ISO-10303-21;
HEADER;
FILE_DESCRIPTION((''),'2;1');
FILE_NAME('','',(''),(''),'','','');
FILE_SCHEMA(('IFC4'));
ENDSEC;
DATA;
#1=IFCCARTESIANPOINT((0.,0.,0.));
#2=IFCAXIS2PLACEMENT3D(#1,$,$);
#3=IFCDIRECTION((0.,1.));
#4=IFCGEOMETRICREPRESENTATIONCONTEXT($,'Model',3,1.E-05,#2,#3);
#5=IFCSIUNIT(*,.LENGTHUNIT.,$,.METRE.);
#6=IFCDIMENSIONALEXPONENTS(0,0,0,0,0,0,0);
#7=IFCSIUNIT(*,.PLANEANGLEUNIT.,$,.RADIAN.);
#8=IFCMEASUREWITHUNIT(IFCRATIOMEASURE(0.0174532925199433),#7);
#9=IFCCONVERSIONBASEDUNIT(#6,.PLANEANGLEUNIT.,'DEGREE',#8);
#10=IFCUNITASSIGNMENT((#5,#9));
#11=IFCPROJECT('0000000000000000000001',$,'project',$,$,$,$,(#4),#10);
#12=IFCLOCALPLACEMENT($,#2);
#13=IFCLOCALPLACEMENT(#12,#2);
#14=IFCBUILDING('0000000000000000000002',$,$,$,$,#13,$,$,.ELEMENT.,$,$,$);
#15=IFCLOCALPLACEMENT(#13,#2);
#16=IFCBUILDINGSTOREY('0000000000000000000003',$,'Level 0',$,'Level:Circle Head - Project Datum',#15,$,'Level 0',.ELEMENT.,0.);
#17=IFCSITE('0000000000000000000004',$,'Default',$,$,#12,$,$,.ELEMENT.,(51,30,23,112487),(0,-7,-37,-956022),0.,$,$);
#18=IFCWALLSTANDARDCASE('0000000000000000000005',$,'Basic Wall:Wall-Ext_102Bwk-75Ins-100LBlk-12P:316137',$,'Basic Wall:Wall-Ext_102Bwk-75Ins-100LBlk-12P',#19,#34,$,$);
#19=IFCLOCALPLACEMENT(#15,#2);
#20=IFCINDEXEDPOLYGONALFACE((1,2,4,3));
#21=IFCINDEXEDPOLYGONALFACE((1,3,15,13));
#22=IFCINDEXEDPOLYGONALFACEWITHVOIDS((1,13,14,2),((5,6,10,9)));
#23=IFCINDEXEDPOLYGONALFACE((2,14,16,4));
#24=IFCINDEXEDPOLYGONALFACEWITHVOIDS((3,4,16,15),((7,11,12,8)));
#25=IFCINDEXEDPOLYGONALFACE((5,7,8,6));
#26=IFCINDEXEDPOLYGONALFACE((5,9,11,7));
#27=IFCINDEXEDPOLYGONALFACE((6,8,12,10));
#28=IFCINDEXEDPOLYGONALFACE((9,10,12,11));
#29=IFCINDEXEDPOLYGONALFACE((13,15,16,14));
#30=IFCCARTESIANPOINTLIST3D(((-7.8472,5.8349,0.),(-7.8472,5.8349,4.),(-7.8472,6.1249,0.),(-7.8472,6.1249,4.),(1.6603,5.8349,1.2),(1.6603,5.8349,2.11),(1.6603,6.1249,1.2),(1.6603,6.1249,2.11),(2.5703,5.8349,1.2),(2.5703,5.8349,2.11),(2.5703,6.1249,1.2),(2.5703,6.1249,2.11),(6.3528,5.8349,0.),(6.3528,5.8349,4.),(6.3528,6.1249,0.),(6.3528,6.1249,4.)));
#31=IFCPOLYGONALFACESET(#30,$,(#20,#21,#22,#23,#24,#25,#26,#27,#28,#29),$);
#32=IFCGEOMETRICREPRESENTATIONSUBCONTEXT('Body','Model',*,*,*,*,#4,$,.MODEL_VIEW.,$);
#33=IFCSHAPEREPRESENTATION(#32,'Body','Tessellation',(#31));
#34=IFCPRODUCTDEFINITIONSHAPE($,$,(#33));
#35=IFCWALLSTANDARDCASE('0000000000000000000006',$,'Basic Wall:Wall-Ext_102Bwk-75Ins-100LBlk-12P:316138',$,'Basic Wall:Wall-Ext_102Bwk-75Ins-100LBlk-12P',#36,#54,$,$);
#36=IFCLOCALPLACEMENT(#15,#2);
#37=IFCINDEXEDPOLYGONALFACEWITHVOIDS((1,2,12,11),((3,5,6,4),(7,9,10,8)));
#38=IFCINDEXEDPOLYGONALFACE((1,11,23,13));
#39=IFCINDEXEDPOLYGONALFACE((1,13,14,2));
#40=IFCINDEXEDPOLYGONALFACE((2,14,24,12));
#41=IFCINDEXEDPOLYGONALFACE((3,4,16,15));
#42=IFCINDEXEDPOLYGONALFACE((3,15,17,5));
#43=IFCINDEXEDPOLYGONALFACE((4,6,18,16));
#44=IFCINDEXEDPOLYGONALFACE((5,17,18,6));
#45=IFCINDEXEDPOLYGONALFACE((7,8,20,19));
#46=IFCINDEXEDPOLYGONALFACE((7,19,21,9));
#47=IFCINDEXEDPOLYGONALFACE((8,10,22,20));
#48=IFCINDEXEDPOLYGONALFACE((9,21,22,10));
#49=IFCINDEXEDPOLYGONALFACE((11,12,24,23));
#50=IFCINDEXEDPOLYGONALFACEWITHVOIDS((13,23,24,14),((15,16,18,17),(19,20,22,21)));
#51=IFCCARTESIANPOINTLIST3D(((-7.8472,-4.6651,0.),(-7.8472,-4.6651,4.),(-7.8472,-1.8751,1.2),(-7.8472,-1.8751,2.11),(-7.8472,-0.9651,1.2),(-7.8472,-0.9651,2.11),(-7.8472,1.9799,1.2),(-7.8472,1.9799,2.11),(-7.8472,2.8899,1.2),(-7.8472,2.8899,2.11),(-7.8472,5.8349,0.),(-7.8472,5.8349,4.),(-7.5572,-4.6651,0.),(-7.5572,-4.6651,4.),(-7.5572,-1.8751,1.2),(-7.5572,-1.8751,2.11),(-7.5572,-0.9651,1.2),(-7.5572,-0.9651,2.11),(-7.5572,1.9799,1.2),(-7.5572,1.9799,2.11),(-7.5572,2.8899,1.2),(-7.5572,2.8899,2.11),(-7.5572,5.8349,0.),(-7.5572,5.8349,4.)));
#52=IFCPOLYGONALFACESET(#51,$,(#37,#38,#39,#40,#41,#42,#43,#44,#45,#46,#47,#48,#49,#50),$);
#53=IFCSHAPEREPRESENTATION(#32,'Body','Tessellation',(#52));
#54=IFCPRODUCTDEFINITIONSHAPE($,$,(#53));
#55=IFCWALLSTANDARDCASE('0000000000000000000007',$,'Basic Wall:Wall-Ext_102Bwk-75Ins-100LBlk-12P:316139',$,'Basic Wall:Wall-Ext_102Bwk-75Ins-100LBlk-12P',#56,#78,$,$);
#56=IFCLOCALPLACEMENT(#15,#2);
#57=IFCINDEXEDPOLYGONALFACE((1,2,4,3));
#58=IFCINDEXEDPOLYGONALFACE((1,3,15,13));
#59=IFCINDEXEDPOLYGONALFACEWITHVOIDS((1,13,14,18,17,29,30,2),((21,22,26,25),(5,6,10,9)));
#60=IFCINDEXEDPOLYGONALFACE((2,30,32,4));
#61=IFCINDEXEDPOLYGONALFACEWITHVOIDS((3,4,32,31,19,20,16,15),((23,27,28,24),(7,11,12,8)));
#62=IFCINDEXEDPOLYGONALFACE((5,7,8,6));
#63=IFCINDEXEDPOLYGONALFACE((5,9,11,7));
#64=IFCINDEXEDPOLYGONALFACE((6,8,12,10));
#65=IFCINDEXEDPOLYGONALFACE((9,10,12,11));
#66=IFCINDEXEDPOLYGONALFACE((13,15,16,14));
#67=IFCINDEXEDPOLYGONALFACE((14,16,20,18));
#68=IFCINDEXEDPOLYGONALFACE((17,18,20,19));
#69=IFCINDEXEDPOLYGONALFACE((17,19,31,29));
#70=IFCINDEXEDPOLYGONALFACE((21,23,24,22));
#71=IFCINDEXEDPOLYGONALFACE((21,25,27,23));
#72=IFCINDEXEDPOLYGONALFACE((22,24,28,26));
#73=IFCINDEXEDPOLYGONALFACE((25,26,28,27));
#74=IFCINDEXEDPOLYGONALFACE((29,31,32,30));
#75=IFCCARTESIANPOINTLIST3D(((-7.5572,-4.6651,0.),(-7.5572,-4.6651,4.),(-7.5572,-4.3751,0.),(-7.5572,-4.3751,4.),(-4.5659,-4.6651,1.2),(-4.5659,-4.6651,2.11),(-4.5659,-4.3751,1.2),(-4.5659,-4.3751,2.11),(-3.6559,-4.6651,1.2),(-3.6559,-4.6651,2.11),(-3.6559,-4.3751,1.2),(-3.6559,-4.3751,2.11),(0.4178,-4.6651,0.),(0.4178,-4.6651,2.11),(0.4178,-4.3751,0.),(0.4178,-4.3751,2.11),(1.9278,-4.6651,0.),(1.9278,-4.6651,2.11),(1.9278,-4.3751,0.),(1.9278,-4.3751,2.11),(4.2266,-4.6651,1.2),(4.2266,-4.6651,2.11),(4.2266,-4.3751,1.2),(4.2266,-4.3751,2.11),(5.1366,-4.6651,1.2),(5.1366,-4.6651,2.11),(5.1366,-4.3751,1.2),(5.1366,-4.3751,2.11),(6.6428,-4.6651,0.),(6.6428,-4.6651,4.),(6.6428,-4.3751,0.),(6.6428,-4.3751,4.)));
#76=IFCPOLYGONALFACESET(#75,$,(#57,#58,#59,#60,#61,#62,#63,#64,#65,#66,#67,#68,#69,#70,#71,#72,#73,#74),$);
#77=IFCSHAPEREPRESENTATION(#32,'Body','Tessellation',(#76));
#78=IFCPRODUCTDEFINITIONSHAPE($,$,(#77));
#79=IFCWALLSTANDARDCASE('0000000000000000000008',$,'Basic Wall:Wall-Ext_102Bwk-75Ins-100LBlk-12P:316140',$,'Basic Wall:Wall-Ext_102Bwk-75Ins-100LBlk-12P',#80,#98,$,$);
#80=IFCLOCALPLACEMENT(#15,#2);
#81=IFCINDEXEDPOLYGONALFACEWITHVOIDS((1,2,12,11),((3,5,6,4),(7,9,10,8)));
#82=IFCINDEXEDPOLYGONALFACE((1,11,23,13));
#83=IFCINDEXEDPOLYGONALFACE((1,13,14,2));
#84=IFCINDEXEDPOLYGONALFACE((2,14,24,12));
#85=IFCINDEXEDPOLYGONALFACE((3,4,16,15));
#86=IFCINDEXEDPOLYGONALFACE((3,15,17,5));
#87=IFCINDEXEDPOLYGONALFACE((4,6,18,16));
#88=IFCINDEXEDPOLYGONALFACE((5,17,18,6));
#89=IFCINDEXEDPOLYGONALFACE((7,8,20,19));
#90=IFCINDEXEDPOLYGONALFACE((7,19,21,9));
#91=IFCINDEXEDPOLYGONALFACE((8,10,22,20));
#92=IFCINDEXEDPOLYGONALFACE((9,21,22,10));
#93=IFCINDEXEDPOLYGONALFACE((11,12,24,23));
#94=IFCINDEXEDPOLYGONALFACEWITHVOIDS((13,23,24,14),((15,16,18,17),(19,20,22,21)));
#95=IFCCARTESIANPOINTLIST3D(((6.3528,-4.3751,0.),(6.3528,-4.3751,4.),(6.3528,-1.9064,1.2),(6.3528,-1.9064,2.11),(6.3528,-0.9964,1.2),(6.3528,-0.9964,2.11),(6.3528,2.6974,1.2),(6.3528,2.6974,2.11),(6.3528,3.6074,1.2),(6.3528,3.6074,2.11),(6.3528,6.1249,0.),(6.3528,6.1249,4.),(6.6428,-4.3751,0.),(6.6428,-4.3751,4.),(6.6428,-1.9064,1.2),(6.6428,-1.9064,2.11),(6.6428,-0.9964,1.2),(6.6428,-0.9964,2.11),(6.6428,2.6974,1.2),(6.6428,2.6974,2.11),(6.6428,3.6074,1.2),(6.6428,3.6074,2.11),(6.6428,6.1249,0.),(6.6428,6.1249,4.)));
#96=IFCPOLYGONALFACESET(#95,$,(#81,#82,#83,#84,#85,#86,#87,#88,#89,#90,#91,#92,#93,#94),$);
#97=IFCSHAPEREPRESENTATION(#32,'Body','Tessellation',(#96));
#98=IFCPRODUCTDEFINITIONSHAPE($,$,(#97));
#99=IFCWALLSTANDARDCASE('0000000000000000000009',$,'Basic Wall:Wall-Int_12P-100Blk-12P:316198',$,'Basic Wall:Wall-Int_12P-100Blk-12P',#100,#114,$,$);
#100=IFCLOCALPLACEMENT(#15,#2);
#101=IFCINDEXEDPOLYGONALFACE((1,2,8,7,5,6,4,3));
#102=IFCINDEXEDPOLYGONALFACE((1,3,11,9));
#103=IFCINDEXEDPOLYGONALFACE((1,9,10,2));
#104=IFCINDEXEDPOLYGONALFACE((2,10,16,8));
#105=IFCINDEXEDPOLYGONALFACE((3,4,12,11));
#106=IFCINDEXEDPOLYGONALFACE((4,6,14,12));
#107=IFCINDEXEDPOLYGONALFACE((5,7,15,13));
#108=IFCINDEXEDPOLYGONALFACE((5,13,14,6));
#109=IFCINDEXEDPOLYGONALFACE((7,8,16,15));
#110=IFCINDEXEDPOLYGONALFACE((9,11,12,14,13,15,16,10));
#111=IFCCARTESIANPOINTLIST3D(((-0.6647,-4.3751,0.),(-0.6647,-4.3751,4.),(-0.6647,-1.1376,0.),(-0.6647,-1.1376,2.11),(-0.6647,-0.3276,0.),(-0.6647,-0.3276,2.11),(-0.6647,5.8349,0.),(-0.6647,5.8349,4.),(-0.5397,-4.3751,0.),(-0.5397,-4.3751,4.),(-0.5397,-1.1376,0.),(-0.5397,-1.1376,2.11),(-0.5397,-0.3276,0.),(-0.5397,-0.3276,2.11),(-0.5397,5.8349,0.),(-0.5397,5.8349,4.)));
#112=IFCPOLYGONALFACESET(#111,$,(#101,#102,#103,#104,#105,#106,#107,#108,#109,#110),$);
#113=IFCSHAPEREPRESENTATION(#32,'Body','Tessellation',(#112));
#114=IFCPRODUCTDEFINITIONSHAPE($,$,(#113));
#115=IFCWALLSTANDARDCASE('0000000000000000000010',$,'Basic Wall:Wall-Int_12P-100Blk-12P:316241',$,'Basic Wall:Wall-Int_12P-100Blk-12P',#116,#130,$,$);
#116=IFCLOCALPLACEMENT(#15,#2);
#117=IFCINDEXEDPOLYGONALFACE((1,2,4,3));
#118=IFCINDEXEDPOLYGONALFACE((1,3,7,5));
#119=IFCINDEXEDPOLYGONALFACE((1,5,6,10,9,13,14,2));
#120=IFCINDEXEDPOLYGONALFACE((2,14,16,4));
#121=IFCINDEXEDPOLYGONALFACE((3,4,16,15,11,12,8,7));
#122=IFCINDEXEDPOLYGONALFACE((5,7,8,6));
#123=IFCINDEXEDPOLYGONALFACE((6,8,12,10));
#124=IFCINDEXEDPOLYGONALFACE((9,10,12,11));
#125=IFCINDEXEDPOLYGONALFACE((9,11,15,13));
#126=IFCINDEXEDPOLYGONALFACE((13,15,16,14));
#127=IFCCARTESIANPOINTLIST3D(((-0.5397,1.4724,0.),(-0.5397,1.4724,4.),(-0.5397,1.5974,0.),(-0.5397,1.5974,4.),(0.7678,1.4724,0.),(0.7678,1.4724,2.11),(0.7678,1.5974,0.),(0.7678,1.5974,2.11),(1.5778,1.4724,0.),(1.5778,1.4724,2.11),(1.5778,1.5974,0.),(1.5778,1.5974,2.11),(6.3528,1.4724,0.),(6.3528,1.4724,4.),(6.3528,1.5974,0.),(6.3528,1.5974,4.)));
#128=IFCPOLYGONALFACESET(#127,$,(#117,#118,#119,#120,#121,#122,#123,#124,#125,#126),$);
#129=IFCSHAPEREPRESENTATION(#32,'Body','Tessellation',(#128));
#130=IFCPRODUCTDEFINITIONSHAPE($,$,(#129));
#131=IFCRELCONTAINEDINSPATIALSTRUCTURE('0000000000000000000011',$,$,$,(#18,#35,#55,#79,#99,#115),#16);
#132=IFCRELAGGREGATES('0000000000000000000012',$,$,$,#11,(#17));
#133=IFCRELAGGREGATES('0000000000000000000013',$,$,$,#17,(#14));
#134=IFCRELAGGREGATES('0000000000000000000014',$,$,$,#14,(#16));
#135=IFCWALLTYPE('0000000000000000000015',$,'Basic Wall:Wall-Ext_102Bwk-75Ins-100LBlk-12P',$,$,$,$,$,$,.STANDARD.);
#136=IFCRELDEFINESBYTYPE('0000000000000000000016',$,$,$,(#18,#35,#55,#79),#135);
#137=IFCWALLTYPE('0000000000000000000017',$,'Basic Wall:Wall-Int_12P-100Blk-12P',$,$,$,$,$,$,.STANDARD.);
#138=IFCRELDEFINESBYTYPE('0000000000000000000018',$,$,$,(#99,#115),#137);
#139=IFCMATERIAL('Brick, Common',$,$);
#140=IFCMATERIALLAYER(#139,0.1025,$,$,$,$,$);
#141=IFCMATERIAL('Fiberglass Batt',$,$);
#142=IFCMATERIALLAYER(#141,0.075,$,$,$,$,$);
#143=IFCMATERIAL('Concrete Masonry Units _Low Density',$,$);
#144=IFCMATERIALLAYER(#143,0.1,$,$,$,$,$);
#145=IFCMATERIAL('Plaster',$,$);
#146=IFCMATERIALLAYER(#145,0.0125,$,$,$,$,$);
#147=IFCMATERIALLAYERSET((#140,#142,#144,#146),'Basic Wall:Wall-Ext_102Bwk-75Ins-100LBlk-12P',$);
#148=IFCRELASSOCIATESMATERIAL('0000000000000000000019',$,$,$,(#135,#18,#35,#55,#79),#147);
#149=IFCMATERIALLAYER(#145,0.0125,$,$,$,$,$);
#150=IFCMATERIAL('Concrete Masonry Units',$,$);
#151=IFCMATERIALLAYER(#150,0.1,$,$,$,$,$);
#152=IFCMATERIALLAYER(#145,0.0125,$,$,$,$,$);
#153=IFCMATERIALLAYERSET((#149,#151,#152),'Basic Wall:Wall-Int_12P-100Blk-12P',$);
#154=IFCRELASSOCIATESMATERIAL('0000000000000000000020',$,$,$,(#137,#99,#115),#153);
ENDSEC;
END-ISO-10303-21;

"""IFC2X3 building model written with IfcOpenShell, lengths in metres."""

from ifc_helpers import new_model, entity, si_unit, converted_unit, direction, frame, frame_2d, origin, place, context, subcontext, project, spatial, rectangle, extrude, material, layer, layer_set, layer_usage, type_object, element, save


model = new_model("IFC2X3")

# Units and contexts
model_context = context("Model", 3, precision=1e-05, world=origin(), true_north=direction((0.0, 1.0)))
body_context = subcontext(model_context, "Body", "Model", "MODEL_VIEW")
ifc_project = project(units=[si_unit("LENGTHUNIT", "METRE"), converted_unit("PLANEANGLEUNIT", "DEGREE", entity("IfcRatioMeasure", 0.0174532925199433), si_unit("PLANEANGLEUNIT", "RADIAN"), dimensions=[0, 0, 0, 0, 0, 0, 0])], contexts=[model_context])

# Site, building, storey
site_placement = place(None, origin())
site = spatial("IfcSite", under=ifc_project, at=site_placement, Name="Default", CompositionType="ELEMENT", RefLatitude=(51, 30, 23, 112487), RefLongitude=(0, -7, -37, -956022), RefElevation=0.0)
building_placement = place(site_placement, origin())
building = spatial("IfcBuilding", under=site, at=building_placement, CompositionType="ELEMENT")
storey_placement = place(building_placement, origin())
storey = spatial("IfcBuildingStorey", under=building, at=storey_placement, Name="Level 0", ObjectType="Level:Circle Head - Project Datum", LongName="Level 0", CompositionType="ELEMENT", Elevation=0.0)

# Wall, opening
ifc_material_1 = material(Name="Brick, Common")
ifc_layer_1 = layer(ifc_material_1, 0.1025)
ifc_material_2 = material(Name="Fiberglass Batt")
ifc_layer_2 = layer(ifc_material_2, 0.075)
ifc_material_3 = material(Name="Concrete Masonry Units _Low Density")
ifc_layer_3 = layer(ifc_material_3, 0.1)
ifc_material_4 = material(Name="Plaster")
ifc_layer_4 = layer(ifc_material_4, 0.0125)
ifc_layer_set_1 = layer_set([ifc_layer_1, ifc_layer_2, ifc_layer_3, ifc_layer_4], Name="Basic Wall:Wall-Ext_102Bwk-75Ins-100LBlk-12P")
ifc_layer_usage_1 = layer_usage(ifc_layer_set_1, "AXIS2", "NEGATIVE", 0.145)
wall_type_1 = type_object("IfcWallType", Name="Basic Wall:Wall-Ext_102Bwk-75Ins-100LBlk-12P", PredefinedType="STANDARD", material=ifc_layer_set_1)
wall_1_placement = place(storey_placement, frame((-7.8472, 5.9799, 0.0)))
wall_1 = element("IfcWallStandardCase", 1, at=wall_1_placement, inside=storey, type_object=wall_type_1, material=ifc_layer_usage_1, Name="Basic Wall:Wall-Ext_102Bwk-75Ins-100LBlk-12P:316137", ObjectType="Basic Wall:Wall-Ext_102Bwk-75Ins-100LBlk-12P", context=body_context, shape_type="SweptSolid", body=[
    extrude(rectangle(XDim=14.2, YDim=0.29, at=frame_2d((7.1, 0.0), x_axis=(-1.0, 0.0))), origin(), (0.0, 0.0, 1.0), 4.0),
])
opening_1_placement = place(wall_1_placement, frame((9.5075, -0.145, 1.2)))
element("IfcOpeningElement", 2, at=opening_1_placement, cuts=wall_1, ObjectType="Opening", context=body_context, shape_type="SweptSolid", body=[
    extrude(rectangle(XDim=0.91, YDim=0.91, at=frame_2d((0.455, 0.455), x_axis=(-1.0, 0.0))), frame((0.0, 0.0, 0.0), z_axis=(0.0, 1.0, 0.0), x_axis=(0.0, 0.0, 1.0)), (0.0, 0.0, 1.0), 0.29),
])

# Walls, openings
ifc_layer_usage_2 = layer_usage(ifc_layer_set_1, "AXIS2", "NEGATIVE", 0.145)
wall_2_placement = place(storey_placement, frame((-7.7022, -4.6651, 0.0), z_axis=(0.0, 0.0, 1.0), x_axis=(0.0, 1.0, 0.0)))
wall_2 = element("IfcWallStandardCase", 3, at=wall_2_placement, inside=storey, type_object=wall_type_1, material=ifc_layer_usage_2, Name="Basic Wall:Wall-Ext_102Bwk-75Ins-100LBlk-12P:316138", ObjectType="Basic Wall:Wall-Ext_102Bwk-75Ins-100LBlk-12P", context=body_context, shape_type="SweptSolid", body=[
    extrude(rectangle(XDim=10.5, YDim=0.29, at=frame_2d((5.25, 0.0), x_axis=(-1.0, 0.0))), origin(), (0.0, 0.0, 1.0), 4.0),
])
opening_2_placement = place(wall_2_placement, frame((2.79, -0.145, 1.2)))
element("IfcOpeningElement", 4, at=opening_2_placement, cuts=wall_2, ObjectType="Opening", context=body_context, shape_type="SweptSolid", body=[
    extrude(rectangle(XDim=0.91, YDim=0.91, at=frame_2d((0.455, 0.455), x_axis=(-1.0, 0.0))), frame((0.0, 0.0, 0.0), z_axis=(0.0, 1.0, 0.0), x_axis=(0.0, 0.0, 1.0)), (0.0, 0.0, 1.0), 0.29),
])
opening_3_placement = place(wall_2_placement, frame((6.645, -0.145, 1.2)))
element("IfcOpeningElement", 5, at=opening_3_placement, cuts=wall_2, ObjectType="Opening", context=body_context, shape_type="SweptSolid", body=[
    extrude(rectangle(XDim=0.91, YDim=0.91, at=frame_2d((0.455, 0.455), x_axis=(-1.0, 0.0))), frame((0.0, 0.0, 0.0), z_axis=(0.0, 1.0, 0.0), x_axis=(0.0, 0.0, 1.0)), (0.0, 0.0, 1.0), 0.29),
])
ifc_layer_usage_3 = layer_usage(ifc_layer_set_1, "AXIS2", "NEGATIVE", 0.145)
wall_3_placement = place(storey_placement, frame((6.6428, -4.5201, 0.0), z_axis=(0.0, 0.0, 1.0), x_axis=(-1.0, 0.0, 0.0)))
wall_3 = element("IfcWallStandardCase", 6, at=wall_3_placement, inside=storey, type_object=wall_type_1, material=ifc_layer_usage_3, Name="Basic Wall:Wall-Ext_102Bwk-75Ins-100LBlk-12P:316139", ObjectType="Basic Wall:Wall-Ext_102Bwk-75Ins-100LBlk-12P", context=body_context, shape_type="SweptSolid", body=[
    extrude(rectangle(XDim=14.2, YDim=0.29, at=frame_2d((7.1, 0.0), x_axis=(-1.0, 0.0))), origin(), (0.0, 0.0, 1.0), 4.0),
])
opening_4_placement = place(wall_3_placement, frame((6.225, 0.145, 0.0)))
element("IfcOpeningElement", 7, at=opening_4_placement, cuts=wall_3, ObjectType="Opening", context=body_context, shape_type="SweptSolid", body=[
    extrude(rectangle(XDim=2.11, YDim=1.51, at=frame_2d((1.055, 0.755), x_axis=(-1.0, 0.0))), frame((0.0, 0.0, 0.0), z_axis=(0.0, -1.0, 0.0), x_axis=(0.0, 0.0, 1.0)), (0.0, 0.0, 1.0), 0.29),
])
opening_5_placement = place(wall_3_placement, frame((11.2088, 0.145, 1.2)))
element("IfcOpeningElement", 8, at=opening_5_placement, cuts=wall_3, ObjectType="Opening", context=body_context, shape_type="SweptSolid", body=[
    extrude(rectangle(XDim=0.91, YDim=0.91, at=frame_2d((0.455, 0.455), x_axis=(-1.0, 0.0))), frame((0.0, 0.0, 0.0), z_axis=(0.0, -1.0, 0.0), x_axis=(0.0, 0.0, 1.0)), (0.0, 0.0, 1.0), 0.29),
])
opening_6_placement = place(wall_3_placement, frame((2.4162, 0.145, 1.2)))
element("IfcOpeningElement", 9, at=opening_6_placement, cuts=wall_3, ObjectType="Opening", context=body_context, shape_type="SweptSolid", body=[
    extrude(rectangle(XDim=0.91, YDim=0.91, at=frame_2d((0.455, 0.455), x_axis=(-1.0, 0.0))), frame((0.0, 0.0, 0.0), z_axis=(0.0, -1.0, 0.0), x_axis=(0.0, 0.0, 1.0)), (0.0, 0.0, 1.0), 0.29),
])
ifc_layer_usage_4 = layer_usage(ifc_layer_set_1, "AXIS2", "NEGATIVE", 0.145)
wall_4_placement = place(storey_placement, frame((6.4978, 6.1249, 0.0), z_axis=(0.0, 0.0, 1.0), x_axis=(0.0, -1.0, 0.0)))
wall_4 = element("IfcWallStandardCase", 10, at=wall_4_placement, inside=storey, type_object=wall_type_1, material=ifc_layer_usage_4, Name="Basic Wall:Wall-Ext_102Bwk-75Ins-100LBlk-12P:316140", ObjectType="Basic Wall:Wall-Ext_102Bwk-75Ins-100LBlk-12P", context=body_context, shape_type="SweptSolid", body=[
    extrude(rectangle(XDim=10.5, YDim=0.29, at=frame_2d((5.25, 0.0), x_axis=(-1.0, 0.0))), origin(), (0.0, 0.0, 1.0), 4.0),
])
opening_7_placement = place(wall_4_placement, frame((2.5175, -0.145, 1.2)))
element("IfcOpeningElement", 11, at=opening_7_placement, cuts=wall_4, ObjectType="Opening", context=body_context, shape_type="SweptSolid", body=[
    extrude(rectangle(XDim=0.91, YDim=0.91, at=frame_2d((0.455, 0.455), x_axis=(-1.0, 0.0))), frame((0.0, 0.0, 0.0), z_axis=(0.0, 1.0, 0.0), x_axis=(0.0, 0.0, 1.0)), (0.0, 0.0, 1.0), 0.29),
])
opening_8_placement = place(wall_4_placement, frame((7.1213, -0.145, 1.2)))
element("IfcOpeningElement", 12, at=opening_8_placement, cuts=wall_4, ObjectType="Opening", context=body_context, shape_type="SweptSolid", body=[
    extrude(rectangle(XDim=0.91, YDim=0.91, at=frame_2d((0.455, 0.455), x_axis=(-1.0, 0.0))), frame((0.0, 0.0, 0.0), z_axis=(0.0, 1.0, 0.0), x_axis=(0.0, 0.0, 1.0)), (0.0, 0.0, 1.0), 0.29),
])

# Walls, openings
ifc_layer_5 = layer(ifc_material_4, 0.0125)
ifc_material_5 = material(Name="Concrete Masonry Units")
ifc_layer_6 = layer(ifc_material_5, 0.1)
ifc_layer_7 = layer(ifc_material_4, 0.0125)
ifc_layer_set_2 = layer_set([ifc_layer_5, ifc_layer_6, ifc_layer_7], Name="Basic Wall:Wall-Int_12P-100Blk-12P")
ifc_layer_usage_5 = layer_usage(ifc_layer_set_2, "AXIS2", "NEGATIVE", 0.0625)
wall_type_2 = type_object("IfcWallType", Name="Basic Wall:Wall-Int_12P-100Blk-12P", PredefinedType="STANDARD", material=ifc_layer_set_2)
wall_5_placement = place(storey_placement, frame((-0.6022, 5.8349, 0.0), z_axis=(0.0, 0.0, 1.0), x_axis=(0.0, -1.0, 0.0)))
wall_5 = element("IfcWallStandardCase", 13, at=wall_5_placement, inside=storey, type_object=wall_type_2, material=ifc_layer_usage_5, Name="Basic Wall:Wall-Int_12P-100Blk-12P:316198", ObjectType="Basic Wall:Wall-Int_12P-100Blk-12P", context=body_context, shape_type="SweptSolid", body=[
    extrude(rectangle(XDim=10.21, YDim=0.125, at=frame_2d((5.105, 0.0), x_axis=(-1.0, 0.0))), origin(), (0.0, 0.0, 1.0), 4.0),
])
opening_9_placement = place(wall_5_placement, frame((6.1625, -0.0625, 0.0)))
element("IfcOpeningElement", 14, at=opening_9_placement, cuts=wall_5, ObjectType="Opening", context=body_context, shape_type="SweptSolid", body=[
    extrude(rectangle(XDim=2.11, YDim=0.81, at=frame_2d((1.055, 0.405), x_axis=(1.0, 0.0))), frame((0.0, 0.0, 0.0), z_axis=(0.0, 1.0, 0.0), x_axis=(0.0, 0.0, 1.0)), (0.0, 0.0, 1.0), 0.125),
])
ifc_layer_usage_6 = layer_usage(ifc_layer_set_2, "AXIS2", "NEGATIVE", 0.0625)
wall_6_placement = place(storey_placement, frame((-0.5397, 1.5349, 0.0)))
wall_6 = element("IfcWallStandardCase", 15, at=wall_6_placement, inside=storey, type_object=wall_type_2, material=ifc_layer_usage_6, Name="Basic Wall:Wall-Int_12P-100Blk-12P:316241", ObjectType="Basic Wall:Wall-Int_12P-100Blk-12P", context=body_context, shape_type="SweptSolid", body=[
    extrude(rectangle(XDim=6.8925, YDim=0.125, at=frame_2d((3.4463, 0.0), x_axis=(-1.0, 0.0))), origin(), (0.0, 0.0, 1.0), 4.0),
])
opening_10_placement = place(wall_6_placement, frame((2.1175, 0.0625, 0.0)))
element("IfcOpeningElement", 16, at=opening_10_placement, cuts=wall_6, ObjectType="Opening", context=body_context, shape_type="SweptSolid", body=[
    extrude(rectangle(XDim=2.11, YDim=0.81, at=frame_2d((1.055, 0.405), x_axis=(1.0, 0.0))), frame((0.0, 0.0, 0.0), z_axis=(0.0, -1.0, 0.0), x_axis=(0.0, 0.0, 1.0)), (0.0, 0.0, 1.0), 0.125),
])

save(model, "model.ifc")
